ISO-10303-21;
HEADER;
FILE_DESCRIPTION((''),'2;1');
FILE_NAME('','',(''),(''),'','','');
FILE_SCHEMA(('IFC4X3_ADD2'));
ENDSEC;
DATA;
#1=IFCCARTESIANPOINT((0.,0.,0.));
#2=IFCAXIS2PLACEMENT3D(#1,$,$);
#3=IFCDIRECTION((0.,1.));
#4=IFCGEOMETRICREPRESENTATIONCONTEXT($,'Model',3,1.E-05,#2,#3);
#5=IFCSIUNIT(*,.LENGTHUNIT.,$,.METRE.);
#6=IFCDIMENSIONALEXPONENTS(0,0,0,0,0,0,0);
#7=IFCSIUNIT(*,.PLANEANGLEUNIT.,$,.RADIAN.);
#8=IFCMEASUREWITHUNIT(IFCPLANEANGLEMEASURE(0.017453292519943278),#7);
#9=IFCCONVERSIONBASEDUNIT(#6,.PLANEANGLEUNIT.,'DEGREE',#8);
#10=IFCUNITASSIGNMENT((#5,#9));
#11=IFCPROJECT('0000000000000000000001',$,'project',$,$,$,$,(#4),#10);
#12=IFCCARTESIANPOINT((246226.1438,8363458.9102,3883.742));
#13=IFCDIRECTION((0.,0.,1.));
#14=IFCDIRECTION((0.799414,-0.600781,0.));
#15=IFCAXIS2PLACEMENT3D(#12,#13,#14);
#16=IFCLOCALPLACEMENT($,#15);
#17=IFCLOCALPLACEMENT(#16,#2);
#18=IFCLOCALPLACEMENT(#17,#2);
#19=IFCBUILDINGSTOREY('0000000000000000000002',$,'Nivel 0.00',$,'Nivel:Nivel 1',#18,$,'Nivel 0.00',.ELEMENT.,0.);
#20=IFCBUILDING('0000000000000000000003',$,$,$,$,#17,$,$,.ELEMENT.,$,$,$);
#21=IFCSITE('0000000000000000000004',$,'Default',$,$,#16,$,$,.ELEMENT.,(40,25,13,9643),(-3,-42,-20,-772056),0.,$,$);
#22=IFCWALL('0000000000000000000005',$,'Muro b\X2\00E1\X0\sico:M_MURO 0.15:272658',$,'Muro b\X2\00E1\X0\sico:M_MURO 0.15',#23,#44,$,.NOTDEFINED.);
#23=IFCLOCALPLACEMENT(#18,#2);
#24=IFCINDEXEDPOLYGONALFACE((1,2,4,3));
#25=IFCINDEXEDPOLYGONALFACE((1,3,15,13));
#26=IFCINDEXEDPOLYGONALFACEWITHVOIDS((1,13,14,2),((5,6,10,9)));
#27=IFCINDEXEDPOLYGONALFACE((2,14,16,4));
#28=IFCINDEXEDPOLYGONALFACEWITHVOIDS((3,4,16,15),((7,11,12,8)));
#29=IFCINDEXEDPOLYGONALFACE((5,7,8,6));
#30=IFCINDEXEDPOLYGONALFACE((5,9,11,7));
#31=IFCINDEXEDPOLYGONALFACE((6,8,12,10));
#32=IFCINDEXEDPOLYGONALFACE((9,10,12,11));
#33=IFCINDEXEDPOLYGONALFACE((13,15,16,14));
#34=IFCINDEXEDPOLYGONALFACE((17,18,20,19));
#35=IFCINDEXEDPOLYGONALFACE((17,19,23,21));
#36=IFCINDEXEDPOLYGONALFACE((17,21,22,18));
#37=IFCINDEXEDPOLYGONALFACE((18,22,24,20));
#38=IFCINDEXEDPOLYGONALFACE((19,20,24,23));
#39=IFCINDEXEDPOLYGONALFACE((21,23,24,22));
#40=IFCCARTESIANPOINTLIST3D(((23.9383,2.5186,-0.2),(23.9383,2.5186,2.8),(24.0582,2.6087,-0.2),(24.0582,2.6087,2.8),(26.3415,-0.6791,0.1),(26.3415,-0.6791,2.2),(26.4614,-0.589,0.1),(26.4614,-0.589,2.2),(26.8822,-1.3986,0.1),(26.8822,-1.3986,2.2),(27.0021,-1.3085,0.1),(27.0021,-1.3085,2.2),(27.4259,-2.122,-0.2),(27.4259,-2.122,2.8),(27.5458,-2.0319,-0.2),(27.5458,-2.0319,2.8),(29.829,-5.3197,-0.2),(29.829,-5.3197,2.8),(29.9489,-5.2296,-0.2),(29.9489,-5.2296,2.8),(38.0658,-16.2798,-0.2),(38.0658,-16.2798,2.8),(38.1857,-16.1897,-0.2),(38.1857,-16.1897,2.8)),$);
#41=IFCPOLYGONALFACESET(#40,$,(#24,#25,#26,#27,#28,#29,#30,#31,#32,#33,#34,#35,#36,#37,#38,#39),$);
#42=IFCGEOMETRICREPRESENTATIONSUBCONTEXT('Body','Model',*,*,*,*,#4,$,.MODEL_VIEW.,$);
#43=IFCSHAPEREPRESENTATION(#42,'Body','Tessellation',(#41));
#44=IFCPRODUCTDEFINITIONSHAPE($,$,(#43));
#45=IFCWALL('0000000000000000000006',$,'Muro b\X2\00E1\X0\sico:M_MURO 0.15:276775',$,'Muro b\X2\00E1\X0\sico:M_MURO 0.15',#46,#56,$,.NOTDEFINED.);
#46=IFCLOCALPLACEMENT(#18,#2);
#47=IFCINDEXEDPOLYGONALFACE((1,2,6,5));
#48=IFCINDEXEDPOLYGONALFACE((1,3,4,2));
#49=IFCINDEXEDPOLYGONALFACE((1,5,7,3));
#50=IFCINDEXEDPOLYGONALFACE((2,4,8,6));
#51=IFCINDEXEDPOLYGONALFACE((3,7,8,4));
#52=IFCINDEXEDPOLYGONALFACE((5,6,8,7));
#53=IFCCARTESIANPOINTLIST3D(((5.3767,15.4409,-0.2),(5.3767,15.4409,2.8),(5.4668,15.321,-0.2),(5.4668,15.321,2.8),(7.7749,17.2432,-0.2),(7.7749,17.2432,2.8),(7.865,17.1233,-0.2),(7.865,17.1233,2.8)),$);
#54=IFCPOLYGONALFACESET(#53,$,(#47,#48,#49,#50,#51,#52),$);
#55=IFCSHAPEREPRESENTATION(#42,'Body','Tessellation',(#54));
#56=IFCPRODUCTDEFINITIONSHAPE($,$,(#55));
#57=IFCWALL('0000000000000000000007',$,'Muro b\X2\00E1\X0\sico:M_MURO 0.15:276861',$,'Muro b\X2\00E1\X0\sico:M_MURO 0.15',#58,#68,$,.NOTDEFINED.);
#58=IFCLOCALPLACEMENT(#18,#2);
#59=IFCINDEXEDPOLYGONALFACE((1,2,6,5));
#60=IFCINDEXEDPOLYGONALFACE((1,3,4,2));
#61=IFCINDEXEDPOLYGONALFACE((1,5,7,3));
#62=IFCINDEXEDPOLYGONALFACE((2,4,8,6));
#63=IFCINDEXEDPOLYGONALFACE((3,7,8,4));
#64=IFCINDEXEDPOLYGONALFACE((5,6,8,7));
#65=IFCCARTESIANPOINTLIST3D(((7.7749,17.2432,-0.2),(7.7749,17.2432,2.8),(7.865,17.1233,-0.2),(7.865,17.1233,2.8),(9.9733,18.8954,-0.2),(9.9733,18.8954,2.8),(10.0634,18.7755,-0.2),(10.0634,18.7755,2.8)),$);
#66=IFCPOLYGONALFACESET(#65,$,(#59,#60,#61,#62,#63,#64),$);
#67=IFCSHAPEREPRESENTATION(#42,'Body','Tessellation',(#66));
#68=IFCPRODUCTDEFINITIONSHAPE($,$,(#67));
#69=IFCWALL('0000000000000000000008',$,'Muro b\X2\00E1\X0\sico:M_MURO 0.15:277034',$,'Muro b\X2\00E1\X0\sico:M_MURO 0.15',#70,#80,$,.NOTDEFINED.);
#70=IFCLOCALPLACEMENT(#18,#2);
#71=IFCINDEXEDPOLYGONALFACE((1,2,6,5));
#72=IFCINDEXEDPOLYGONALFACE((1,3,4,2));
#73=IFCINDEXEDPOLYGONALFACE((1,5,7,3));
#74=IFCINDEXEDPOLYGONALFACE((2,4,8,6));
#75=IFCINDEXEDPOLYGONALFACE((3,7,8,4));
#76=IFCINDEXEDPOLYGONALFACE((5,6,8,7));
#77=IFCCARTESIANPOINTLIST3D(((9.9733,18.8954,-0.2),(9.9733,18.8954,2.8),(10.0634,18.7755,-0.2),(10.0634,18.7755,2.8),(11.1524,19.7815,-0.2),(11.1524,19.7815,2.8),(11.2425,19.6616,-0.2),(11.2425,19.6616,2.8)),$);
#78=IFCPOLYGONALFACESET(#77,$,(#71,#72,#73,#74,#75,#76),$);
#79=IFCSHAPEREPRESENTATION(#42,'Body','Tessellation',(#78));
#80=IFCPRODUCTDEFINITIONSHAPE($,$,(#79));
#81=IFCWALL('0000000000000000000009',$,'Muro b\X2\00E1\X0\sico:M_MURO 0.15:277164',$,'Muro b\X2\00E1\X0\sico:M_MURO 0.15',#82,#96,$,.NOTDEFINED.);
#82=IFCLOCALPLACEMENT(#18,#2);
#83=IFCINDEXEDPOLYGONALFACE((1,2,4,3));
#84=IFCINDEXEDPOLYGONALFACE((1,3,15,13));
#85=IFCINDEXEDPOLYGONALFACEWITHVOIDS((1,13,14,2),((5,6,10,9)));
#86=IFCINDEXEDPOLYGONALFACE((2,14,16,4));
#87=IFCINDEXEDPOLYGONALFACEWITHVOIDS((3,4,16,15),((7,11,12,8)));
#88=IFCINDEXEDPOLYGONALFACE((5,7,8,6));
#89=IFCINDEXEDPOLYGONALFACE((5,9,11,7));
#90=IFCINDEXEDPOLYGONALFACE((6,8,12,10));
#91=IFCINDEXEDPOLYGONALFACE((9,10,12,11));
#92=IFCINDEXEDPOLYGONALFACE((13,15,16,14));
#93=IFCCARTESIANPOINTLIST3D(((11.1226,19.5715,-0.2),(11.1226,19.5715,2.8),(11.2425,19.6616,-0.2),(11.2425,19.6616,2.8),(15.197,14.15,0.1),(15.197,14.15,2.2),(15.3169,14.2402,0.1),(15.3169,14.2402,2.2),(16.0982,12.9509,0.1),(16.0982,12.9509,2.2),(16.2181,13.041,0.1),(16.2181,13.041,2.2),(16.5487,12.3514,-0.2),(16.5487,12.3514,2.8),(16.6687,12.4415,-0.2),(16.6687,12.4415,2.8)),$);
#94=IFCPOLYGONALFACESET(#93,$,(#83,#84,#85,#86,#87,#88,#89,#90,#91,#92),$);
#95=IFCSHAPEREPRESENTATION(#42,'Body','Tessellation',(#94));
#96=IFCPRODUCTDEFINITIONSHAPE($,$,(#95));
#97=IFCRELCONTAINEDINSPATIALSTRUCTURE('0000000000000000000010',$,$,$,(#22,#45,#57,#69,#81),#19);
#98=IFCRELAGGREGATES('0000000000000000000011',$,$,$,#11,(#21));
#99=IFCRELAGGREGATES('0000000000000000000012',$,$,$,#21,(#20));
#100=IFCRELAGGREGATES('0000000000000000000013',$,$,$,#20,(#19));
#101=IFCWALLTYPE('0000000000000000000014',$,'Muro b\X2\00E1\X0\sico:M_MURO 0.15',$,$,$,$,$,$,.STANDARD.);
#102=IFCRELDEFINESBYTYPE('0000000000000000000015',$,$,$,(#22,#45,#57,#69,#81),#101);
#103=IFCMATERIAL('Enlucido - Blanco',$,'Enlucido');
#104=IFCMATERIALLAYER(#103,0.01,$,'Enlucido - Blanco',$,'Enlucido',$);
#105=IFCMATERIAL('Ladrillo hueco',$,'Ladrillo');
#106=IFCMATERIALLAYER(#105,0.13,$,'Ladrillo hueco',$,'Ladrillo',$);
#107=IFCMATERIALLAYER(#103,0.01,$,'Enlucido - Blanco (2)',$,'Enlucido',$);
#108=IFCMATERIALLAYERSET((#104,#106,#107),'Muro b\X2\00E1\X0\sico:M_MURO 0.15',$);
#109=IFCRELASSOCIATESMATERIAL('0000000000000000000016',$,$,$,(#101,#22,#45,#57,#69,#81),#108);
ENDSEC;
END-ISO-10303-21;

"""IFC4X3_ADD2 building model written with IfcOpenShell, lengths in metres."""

from ifc_helpers import new_model, entity, si_unit, converted_unit, direction, frame, frame_2d, origin, place, context, subcontext, project, spatial, rectangle, extrude, material, layer, layer_set, type_object, element, save


model = new_model("IFC4X3_ADD2")

# Units and contexts
model_context = context("Model", 3, precision=1e-05, world=origin(), true_north=direction((0.0, 1.0)))
body_context = subcontext(model_context, "Body", "Model", "MODEL_VIEW")
ifc_project = project(units=[si_unit("LENGTHUNIT", "METRE"), converted_unit("PLANEANGLEUNIT", "DEGREE", entity("IfcPlaneAngleMeasure", 0.017453292519943278), si_unit("PLANEANGLEUNIT", "RADIAN"), dimensions=[0, 0, 0, 0, 0, 0, 0])], contexts=[model_context])

# Site, building, storey
site_placement = place(None, frame((246226.1438, 8363458.9102, 3883.742), z_axis=(0.0, 0.0, 1.0), x_axis=(0.799414, -0.600781, 0.0)))
site = spatial("IfcSite", under=ifc_project, at=site_placement, Name="Default", CompositionType="ELEMENT", RefLatitude=(40, 25, 13, 9643), RefLongitude=(-3, -42, -20, -772056), RefElevation=0.0)
building_placement = place(site_placement, origin())
building = spatial("IfcBuilding", under=site, at=building_placement, CompositionType="ELEMENT")
storey_placement = place(building_placement, origin())
storey = spatial("IfcBuildingStorey", under=building, at=storey_placement, Name="Nivel 0.00", ObjectType="Nivel:Nivel 1", LongName="Nivel 0.00", CompositionType="ELEMENT", Elevation=0.0)

# Shared definitions
ifc_material_1 = material(Name="Enlucido - Blanco", Category="Enlucido")
ifc_layer_1 = layer(ifc_material_1, 0.01, Name="Enlucido - Blanco", Category="Enlucido")
ifc_material_2 = material(Name="Ladrillo hueco", Category="Ladrillo")
ifc_layer_2 = layer(ifc_material_2, 0.13, Name="Ladrillo hueco", Category="Ladrillo")
ifc_layer_3 = layer(ifc_material_1, 0.01, Name="Enlucido - Blanco (2)", Category="Enlucido")
ifc_layer_set_1 = layer_set([ifc_layer_1, ifc_layer_2, ifc_layer_3], Name="Muro básico:M_MURO 0.15")
wall_type = type_object("IfcWallType", Name="Muro básico:M_MURO 0.15", PredefinedType="STANDARD", material=ifc_layer_set_1)

# Wall, openings
wall_1_placement = place(storey_placement, frame((23.9983, 2.5636, -0.2), z_axis=(0.0, 0.0, 1.0), x_axis=(0.60078, -0.799414, 0.0)))
wall_1 = element("IfcWall", 1, at=wall_1_placement, inside=storey, type_object=wall_type, material=ifc_layer_set_1, Name="Muro básico:M_MURO 0.15:272658", ObjectType="Muro básico:M_MURO 0.15", PredefinedType="NOTDEFINED", context=body_context, shape_type="SweptSolid", body=[
    extrude(rectangle(XDim=0.15, YDim=23.5152, at=frame_2d((11.7576, 0.0), x_axis=(0.0, -1.0))), origin(), (0.0, 0.0, 1.0), 3.0),
])
opening_1_placement = place(wall_1_placement, frame((9.805, 0.075, 0.0)))
element("IfcOpeningElement", 2, at=opening_1_placement, cuts=wall_1, PredefinedType="OPENING", context=body_context, shape_type="SweptSolid", body=[
    extrude(rectangle(XDim=3.065, YDim=4.0, at=frame_2d((1.5325, 2.0), x_axis=(1.0, 0.0))), frame((0.0, 0.0, 0.0), z_axis=(0.0, -1.0, 0.0), x_axis=(0.0, 0.0, 1.0)), (0.0, 0.0, 1.0), 0.15),
])
opening_2_placement = place(wall_1_placement, frame((4.0, -0.075, 0.3)))
element("IfcOpeningElement", 3, at=opening_2_placement, cuts=wall_1, PredefinedType="OPENING", context=body_context, shape_type="SweptSolid", body=[
    extrude(rectangle(XDim=2.1, YDim=0.9, at=frame_2d((1.05, 0.45), x_axis=(1.0, 0.0))), frame((0.0, 0.0, 0.0), z_axis=(0.0, 1.0, 0.0), x_axis=(0.0, 0.0, 1.0)), (0.0, 0.0, 1.0), 0.15),
])

# Walls
wall_2_placement = place(storey_placement, frame((5.4217, 15.3809, -0.2), z_axis=(0.0, 0.0, 1.0), x_axis=(0.799414, 0.60078, 0.0)))
element("IfcWall", 4, at=wall_2_placement, inside=storey, type_object=wall_type, material=ifc_layer_set_1, Name="Muro básico:M_MURO 0.15:276775", ObjectType="Muro básico:M_MURO 0.15", PredefinedType="NOTDEFINED", context=body_context, shape_type="SweptSolid", body=[
    extrude(rectangle(XDim=3.0, YDim=0.15, at=frame_2d((1.5, 0.0), x_axis=(-1.0, 0.0))), origin(), (0.0, 0.0, 1.0), 3.0),
])
wall_3_placement = place(storey_placement, frame((7.82, 17.1833, -0.2), z_axis=(0.0, 0.0, 1.0), x_axis=(0.799414, 0.60078, 0.0)))
element("IfcWall", 5, at=wall_3_placement, inside=storey, type_object=wall_type, material=ifc_layer_set_1, Name="Muro básico:M_MURO 0.15:276861", ObjectType="Muro básico:M_MURO 0.15", PredefinedType="NOTDEFINED", context=body_context, shape_type="SweptSolid", body=[
    extrude(rectangle(XDim=2.75, YDim=0.15, at=frame_2d((1.375, 0.0), x_axis=(-1.0, 0.0))), origin(), (0.0, 0.0, 1.0), 3.0),
])
wall_4_placement = place(storey_placement, frame((10.0183, 18.8354, -0.2), z_axis=(0.0, 0.0, 1.0), x_axis=(0.799414, 0.60078, 0.0)))
element("IfcWall", 6, at=wall_4_placement, inside=storey, type_object=wall_type, material=ifc_layer_set_1, Name="Muro básico:M_MURO 0.15:277034", ObjectType="Muro básico:M_MURO 0.15", PredefinedType="NOTDEFINED", context=body_context, shape_type="SweptSolid", body=[
    extrude(rectangle(XDim=1.475, YDim=0.15, at=frame_2d((0.7375, 0.0), x_axis=(-1.0, 0.0))), origin(), (0.0, 0.0, 1.0), 3.0),
])

# Wall, openings
wall_5_placement = place(storey_placement, frame((11.1826, 19.6166, -0.2), z_axis=(0.0, 0.0, 1.0), x_axis=(0.60078, -0.799414, 0.0)))
wall_5 = element("IfcWall", 7, at=wall_5_placement, inside=storey, type_object=wall_type, material=ifc_layer_set_1, Name="Muro básico:M_MURO 0.15:277164", ObjectType="Muro básico:M_MURO 0.15", PredefinedType="NOTDEFINED", context=body_context, shape_type="SweptSolid", body=[
    extrude(rectangle(XDim=9.0318, YDim=0.15, at=frame_2d((4.5159, 0.0), x_axis=(-1.0, 0.0))), origin(), (0.0, 0.0, 1.0), 3.0),
])
opening_3_placement = place(wall_5_placement, frame((6.7818, -0.075, 0.3)))
element("IfcOpeningElement", 8, at=opening_3_placement, cuts=wall_5, PredefinedType="OPENING", context=body_context, shape_type="SweptSolid", body=[
    extrude(rectangle(XDim=2.1, YDim=1.5, at=frame_2d((1.05, 0.75), x_axis=(1.0, 0.0))), frame((0.0, 0.0, 0.0), z_axis=(0.0, 1.0, 0.0), x_axis=(0.0, 0.0, 1.0)), (0.0, 0.0, 1.0), 0.15),
])
opening_4_placement = place(wall_5_placement, frame((8.9635, -20.7247, 0.3), z_axis=(0.0, 0.0, 1.0), x_axis=(0.60078, 0.799414, 0.0)))
element("IfcOpeningElement", 9, at=opening_4_placement, cuts=wall_5, PredefinedType="OPENING", context=body_context, shape_type="SweptSolid", body=[
    extrude(rectangle(XDim=2.1, YDim=1.5, at=frame_2d((0.0, 0.0), x_axis=(0.0, 1.0))), frame((14.4293, 12.6349, 1.05), z_axis=(0.799414, 0.60078, 0.0), x_axis=(-0.60078, 0.799414, 0.0)), (0.0, 0.0, 1.0), 3.048),
])

save(model, "model.ifc")
